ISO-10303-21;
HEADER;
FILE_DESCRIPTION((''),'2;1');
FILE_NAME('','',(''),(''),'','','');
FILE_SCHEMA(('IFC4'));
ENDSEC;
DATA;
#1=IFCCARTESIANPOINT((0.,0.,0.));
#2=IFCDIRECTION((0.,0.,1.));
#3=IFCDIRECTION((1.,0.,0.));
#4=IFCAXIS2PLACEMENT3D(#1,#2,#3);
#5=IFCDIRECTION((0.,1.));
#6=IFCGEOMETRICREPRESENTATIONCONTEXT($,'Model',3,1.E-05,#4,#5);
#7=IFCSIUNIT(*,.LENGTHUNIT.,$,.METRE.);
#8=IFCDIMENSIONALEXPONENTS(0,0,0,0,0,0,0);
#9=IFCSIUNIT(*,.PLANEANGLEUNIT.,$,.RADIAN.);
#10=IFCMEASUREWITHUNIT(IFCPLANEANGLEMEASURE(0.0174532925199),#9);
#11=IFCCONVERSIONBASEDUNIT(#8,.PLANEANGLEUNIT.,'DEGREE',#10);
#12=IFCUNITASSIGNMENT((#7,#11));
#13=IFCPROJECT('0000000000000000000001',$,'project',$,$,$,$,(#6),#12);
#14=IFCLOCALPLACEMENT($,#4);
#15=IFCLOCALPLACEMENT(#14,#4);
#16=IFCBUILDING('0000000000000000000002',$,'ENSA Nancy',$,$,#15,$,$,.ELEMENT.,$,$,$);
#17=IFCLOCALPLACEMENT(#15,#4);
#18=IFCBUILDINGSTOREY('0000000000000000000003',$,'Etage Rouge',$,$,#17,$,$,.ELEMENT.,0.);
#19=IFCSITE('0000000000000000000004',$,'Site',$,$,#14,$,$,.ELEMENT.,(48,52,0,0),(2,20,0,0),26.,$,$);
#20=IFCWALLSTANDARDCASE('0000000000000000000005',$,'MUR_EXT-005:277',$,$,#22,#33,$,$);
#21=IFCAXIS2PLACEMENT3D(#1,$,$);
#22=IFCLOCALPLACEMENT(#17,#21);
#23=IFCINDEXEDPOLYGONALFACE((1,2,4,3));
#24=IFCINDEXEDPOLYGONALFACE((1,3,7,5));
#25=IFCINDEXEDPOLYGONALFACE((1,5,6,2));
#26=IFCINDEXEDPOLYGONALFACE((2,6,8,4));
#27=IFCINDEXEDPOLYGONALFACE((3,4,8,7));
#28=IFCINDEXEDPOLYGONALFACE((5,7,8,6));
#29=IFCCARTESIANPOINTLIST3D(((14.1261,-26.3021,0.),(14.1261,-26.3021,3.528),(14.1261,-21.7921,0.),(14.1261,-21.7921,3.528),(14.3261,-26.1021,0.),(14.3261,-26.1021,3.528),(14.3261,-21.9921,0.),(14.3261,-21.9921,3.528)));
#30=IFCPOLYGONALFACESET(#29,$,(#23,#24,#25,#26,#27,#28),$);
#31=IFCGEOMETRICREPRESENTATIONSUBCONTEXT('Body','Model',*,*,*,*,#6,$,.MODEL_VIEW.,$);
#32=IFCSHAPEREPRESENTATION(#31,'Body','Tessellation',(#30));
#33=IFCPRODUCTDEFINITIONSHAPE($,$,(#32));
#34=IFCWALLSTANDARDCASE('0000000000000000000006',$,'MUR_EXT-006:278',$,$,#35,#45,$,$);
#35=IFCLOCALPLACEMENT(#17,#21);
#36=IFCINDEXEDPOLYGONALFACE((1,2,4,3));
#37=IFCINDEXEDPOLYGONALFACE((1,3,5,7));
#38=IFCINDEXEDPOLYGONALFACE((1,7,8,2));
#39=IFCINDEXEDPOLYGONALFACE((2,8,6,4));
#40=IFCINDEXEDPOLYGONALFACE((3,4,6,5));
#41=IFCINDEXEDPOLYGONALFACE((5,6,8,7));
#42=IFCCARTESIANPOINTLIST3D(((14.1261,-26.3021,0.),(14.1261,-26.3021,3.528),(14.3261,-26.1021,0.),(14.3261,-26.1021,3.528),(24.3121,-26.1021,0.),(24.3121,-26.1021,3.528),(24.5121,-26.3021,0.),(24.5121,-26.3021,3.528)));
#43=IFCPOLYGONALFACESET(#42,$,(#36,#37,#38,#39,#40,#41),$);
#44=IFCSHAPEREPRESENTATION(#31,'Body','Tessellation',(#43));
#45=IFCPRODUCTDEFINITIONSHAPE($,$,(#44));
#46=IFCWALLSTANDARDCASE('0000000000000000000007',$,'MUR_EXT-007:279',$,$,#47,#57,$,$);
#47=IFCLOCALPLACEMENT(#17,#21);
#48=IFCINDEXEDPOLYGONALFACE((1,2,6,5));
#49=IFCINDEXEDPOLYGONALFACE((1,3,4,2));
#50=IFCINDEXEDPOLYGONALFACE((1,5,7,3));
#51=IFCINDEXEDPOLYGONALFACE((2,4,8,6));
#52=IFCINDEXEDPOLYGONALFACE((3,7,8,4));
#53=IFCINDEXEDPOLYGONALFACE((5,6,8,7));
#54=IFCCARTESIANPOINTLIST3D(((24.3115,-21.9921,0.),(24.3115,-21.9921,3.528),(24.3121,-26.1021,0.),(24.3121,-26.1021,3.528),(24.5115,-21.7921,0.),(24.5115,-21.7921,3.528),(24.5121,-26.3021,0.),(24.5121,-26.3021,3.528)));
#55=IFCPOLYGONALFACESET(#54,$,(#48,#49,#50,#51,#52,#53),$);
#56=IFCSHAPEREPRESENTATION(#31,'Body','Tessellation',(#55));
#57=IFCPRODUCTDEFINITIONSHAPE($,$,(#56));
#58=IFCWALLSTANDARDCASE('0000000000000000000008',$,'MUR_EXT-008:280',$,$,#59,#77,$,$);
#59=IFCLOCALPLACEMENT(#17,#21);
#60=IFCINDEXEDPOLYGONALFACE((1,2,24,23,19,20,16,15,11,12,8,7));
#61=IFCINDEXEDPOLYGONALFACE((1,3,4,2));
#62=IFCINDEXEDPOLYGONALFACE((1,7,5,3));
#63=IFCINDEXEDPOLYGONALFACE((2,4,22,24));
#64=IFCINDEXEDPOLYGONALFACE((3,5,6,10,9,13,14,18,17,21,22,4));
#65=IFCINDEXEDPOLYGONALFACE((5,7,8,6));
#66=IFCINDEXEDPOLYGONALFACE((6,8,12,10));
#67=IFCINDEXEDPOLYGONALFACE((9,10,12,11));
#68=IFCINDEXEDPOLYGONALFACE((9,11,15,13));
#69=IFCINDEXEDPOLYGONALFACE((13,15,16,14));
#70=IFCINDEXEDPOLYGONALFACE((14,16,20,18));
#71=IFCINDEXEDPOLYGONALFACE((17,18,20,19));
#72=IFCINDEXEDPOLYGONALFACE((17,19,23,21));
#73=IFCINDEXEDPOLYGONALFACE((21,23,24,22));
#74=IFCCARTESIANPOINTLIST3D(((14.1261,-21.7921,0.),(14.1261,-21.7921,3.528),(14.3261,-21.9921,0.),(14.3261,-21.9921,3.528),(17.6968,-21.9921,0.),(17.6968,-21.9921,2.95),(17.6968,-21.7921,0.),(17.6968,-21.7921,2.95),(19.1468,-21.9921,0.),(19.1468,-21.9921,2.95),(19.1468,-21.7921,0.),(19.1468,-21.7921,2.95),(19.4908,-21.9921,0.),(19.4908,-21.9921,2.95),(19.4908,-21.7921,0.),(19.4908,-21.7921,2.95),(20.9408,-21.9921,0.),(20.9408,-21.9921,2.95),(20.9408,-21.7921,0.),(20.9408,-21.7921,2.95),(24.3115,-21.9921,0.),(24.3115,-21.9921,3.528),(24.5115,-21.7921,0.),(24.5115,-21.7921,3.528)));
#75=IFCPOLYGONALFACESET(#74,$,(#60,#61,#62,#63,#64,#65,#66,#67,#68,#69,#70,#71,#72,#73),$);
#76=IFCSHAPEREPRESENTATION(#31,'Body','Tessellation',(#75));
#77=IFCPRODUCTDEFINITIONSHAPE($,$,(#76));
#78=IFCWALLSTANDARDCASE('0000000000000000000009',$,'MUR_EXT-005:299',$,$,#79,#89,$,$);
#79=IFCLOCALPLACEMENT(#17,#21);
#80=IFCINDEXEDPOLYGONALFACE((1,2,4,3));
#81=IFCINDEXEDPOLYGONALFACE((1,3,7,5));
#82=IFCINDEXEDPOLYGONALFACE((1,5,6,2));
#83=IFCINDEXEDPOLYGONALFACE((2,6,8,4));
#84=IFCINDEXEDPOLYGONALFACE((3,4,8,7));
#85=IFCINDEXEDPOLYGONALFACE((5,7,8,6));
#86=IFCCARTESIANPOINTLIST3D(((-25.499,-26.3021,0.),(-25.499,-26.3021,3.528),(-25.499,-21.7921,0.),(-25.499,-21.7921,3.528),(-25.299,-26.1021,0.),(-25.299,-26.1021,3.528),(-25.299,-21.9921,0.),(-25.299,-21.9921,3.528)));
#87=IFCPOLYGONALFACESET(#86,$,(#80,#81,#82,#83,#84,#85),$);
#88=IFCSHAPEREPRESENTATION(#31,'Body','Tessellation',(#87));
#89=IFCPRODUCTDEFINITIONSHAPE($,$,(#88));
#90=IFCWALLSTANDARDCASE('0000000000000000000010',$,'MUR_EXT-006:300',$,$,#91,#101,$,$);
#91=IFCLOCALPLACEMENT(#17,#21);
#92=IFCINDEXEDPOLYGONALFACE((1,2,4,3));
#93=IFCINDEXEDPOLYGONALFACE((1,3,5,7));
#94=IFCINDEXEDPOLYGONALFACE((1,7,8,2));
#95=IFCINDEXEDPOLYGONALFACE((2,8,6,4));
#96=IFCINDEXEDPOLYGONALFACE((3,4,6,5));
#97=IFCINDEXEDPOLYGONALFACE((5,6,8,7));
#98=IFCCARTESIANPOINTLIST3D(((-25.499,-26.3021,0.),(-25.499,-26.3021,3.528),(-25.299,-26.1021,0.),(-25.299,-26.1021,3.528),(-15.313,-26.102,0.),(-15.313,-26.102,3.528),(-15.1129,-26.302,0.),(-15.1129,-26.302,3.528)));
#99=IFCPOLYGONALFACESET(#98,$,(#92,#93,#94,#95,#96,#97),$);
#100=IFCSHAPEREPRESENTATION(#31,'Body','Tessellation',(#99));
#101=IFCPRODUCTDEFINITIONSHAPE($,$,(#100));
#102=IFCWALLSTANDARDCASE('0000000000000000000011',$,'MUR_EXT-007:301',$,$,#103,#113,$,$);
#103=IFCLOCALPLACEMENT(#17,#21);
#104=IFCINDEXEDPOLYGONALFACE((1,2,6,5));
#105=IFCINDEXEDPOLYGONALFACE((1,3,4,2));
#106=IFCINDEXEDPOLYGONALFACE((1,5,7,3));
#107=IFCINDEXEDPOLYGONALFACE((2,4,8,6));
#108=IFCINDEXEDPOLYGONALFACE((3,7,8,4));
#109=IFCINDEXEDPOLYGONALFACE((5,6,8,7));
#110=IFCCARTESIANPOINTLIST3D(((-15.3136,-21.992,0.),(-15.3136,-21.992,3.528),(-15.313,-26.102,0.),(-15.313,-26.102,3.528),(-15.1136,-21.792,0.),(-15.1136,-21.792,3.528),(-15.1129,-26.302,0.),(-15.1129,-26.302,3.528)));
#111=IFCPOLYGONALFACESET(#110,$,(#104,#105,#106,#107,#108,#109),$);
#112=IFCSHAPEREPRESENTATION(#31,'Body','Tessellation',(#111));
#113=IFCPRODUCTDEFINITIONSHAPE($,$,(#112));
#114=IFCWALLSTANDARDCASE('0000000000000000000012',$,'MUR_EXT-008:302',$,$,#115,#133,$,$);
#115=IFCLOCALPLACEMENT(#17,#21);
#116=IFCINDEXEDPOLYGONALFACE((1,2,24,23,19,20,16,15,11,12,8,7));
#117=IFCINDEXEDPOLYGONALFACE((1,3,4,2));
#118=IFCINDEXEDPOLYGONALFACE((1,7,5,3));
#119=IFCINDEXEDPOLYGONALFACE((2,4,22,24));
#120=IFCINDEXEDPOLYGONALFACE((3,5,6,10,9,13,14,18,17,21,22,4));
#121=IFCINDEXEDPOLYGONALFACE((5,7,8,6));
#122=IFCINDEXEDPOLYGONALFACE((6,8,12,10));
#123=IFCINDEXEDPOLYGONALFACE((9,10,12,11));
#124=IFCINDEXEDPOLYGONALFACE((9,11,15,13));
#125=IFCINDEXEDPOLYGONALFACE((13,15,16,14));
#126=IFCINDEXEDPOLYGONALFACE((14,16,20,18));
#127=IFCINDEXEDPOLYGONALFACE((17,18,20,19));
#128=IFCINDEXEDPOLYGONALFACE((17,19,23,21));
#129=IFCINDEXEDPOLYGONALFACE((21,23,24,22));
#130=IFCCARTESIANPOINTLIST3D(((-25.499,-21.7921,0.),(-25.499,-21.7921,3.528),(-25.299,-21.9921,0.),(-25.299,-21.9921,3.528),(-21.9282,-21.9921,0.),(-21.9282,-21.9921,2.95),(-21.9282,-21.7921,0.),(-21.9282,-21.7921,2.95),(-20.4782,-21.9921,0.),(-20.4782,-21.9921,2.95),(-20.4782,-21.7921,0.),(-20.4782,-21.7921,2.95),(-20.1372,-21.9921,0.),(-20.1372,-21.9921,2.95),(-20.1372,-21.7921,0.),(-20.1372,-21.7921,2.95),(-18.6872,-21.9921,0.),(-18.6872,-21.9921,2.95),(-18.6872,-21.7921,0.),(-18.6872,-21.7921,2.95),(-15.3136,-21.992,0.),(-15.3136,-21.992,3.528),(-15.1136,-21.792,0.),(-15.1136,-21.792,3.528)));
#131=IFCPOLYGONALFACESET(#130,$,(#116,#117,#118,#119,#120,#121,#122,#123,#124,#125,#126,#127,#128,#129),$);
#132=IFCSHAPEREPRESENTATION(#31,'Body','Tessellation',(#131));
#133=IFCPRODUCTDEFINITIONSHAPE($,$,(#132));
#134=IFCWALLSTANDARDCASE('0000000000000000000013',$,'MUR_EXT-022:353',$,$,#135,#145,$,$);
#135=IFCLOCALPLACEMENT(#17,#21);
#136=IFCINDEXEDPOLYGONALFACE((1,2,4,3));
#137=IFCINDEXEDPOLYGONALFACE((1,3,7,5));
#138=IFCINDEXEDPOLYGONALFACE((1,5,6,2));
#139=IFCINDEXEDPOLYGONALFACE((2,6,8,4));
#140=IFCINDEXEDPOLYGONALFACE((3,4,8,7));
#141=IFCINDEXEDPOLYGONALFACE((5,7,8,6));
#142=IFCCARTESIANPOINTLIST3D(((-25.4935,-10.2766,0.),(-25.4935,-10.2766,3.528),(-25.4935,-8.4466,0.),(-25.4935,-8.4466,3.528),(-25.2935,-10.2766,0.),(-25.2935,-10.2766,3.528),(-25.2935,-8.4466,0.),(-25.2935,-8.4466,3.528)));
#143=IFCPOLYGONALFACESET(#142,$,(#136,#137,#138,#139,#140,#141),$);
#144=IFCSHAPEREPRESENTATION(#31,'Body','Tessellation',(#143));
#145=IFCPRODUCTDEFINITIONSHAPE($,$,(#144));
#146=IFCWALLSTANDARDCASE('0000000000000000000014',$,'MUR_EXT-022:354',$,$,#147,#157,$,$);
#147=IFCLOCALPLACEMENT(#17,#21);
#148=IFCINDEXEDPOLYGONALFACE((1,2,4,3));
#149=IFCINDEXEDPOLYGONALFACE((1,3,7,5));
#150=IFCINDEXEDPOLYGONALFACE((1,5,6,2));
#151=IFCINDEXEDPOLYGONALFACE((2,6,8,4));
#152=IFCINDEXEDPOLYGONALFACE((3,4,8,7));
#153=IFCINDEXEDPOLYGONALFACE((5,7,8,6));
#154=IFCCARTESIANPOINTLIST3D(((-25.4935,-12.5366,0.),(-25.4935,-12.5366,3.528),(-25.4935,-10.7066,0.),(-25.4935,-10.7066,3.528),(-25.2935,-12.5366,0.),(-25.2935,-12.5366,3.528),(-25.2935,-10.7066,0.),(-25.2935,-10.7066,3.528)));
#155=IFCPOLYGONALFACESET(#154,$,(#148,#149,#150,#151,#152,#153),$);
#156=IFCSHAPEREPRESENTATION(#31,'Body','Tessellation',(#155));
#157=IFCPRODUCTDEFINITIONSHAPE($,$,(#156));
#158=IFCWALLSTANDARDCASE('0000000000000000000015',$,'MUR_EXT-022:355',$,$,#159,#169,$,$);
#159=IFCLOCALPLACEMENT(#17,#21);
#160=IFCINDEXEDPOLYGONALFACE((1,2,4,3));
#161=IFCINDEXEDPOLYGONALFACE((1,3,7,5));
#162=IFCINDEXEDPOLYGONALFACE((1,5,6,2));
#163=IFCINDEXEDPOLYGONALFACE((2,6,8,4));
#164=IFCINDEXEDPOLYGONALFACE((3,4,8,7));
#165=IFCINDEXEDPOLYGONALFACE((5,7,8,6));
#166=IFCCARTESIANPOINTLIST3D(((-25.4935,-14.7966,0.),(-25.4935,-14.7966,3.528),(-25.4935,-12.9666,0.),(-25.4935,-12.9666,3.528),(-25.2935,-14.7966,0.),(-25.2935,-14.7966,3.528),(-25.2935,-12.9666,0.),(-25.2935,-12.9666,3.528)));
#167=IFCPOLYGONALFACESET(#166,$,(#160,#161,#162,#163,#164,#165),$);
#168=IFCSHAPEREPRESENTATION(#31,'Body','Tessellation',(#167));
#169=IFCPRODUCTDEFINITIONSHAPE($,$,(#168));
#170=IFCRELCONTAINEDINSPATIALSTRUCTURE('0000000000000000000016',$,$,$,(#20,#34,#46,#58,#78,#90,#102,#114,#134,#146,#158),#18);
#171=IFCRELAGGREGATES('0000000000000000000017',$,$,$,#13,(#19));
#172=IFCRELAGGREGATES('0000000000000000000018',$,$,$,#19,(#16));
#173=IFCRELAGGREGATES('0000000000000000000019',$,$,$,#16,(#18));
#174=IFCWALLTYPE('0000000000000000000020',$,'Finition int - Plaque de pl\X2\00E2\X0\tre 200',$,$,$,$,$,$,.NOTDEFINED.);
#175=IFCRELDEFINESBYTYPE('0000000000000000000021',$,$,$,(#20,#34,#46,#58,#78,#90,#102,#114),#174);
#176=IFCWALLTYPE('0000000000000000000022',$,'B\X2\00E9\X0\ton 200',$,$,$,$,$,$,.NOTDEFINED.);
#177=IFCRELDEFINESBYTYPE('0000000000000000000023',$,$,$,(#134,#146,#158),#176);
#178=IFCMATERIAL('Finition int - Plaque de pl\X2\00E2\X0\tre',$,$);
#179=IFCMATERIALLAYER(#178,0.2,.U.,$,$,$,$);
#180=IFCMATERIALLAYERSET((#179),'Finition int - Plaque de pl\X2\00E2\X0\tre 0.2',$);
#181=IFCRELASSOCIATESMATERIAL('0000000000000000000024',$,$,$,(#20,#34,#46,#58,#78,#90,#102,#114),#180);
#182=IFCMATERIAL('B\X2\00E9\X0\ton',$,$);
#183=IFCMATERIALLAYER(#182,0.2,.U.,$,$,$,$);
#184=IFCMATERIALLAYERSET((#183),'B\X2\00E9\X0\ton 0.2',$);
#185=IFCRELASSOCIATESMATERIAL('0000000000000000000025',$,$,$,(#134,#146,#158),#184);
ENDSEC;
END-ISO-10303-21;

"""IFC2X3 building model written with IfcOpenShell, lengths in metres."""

from ifc_helpers import new_model, entity, si_unit, converted_unit, direction, frame, origin_with_axes, origin_2d_with_axis, place, context, subcontext, project, spatial, polyline, rectangle, outline, extrude, material, layer, layer_set, layer_usage, type_object, element, save


model = new_model("IFC2X3")

# Units and contexts
model_context = context("Model", 3, precision=1e-05, world=origin_with_axes(), true_north=direction((0.0, 1.0)))
body_context = subcontext(model_context, "Body", "Model", "MODEL_VIEW")
ifc_project = project(units=[si_unit("LENGTHUNIT", "METRE"), converted_unit("PLANEANGLEUNIT", "DEGREE", entity("IfcPlaneAngleMeasure", 0.0174532925199), si_unit("PLANEANGLEUNIT", "RADIAN"), dimensions=[0, 0, 0, 0, 0, 0, 0])], contexts=[model_context])

# Site, building, storey
site_placement = place(None, origin_with_axes())
site = spatial("IfcSite", under=ifc_project, at=site_placement, Name="Site", CompositionType="ELEMENT", RefLatitude=(48, 52, 0, 0), RefLongitude=(2, 20, 0, 0), RefElevation=26.0)
building_placement = place(site_placement, origin_with_axes())
building = spatial("IfcBuilding", under=site, at=building_placement, Name="ENSA Nancy", CompositionType="ELEMENT")
storey_placement = place(building_placement, origin_with_axes())
storey = spatial("IfcBuildingStorey", under=building, at=storey_placement, Name="Etage Rouge", CompositionType="ELEMENT", Elevation=0.0)

# Walls
ifc_material_1 = material(Name="Finition int - Plaque de plâtre")
ifc_layer_1 = layer(ifc_material_1, 0.2, ventilated="UNKNOWN")
ifc_layer_set_1 = layer_set([ifc_layer_1], Name="Finition int - Plaque de plâtre 0.2")
ifc_layer_usage_1 = layer_usage(ifc_layer_set_1, "AXIS2", "POSITIVE", 0.0)
wall_type_1 = type_object("IfcWallType", Name="Finition int - Plaque de plâtre 200", PredefinedType="NOTDEFINED")
wall_1_placement = place(storey_placement, frame((14.1261, -21.7921, 0.0), z_axis=(0.0, 0.0, 1.0), x_axis=(0.0, -1.0, 0.0)))
element("IfcWallStandardCase", 1, at=wall_1_placement, inside=storey, type_object=wall_type_1, material=ifc_layer_usage_1, Name="MUR_EXT-005:277", context=body_context, shape_type="SweptSolid", body=[
    extrude(outline(polyline([(0.0, 0.0), (4.51, 0.0), (4.31, 0.2), (0.2, 0.2), (0.0, 0.0)])), origin_with_axes(), (0.0, 0.0, 1.0), 3.528),
])
ifc_layer_usage_2 = layer_usage(ifc_layer_set_1, "AXIS2", "POSITIVE", 0.0)
wall_2_placement = place(storey_placement, frame((14.1261, -26.3021, 0.0), z_axis=(0.0, 0.0, 1.0), x_axis=(1.0, 0.000003, 0.0)))
element("IfcWallStandardCase", 2, at=wall_2_placement, inside=storey, type_object=wall_type_1, material=ifc_layer_usage_2, Name="MUR_EXT-006:278", context=body_context, shape_type="SweptSolid", body=[
    extrude(outline(polyline([(0.0, 0.0), (10.386, 0.0), (10.186, 0.2), (0.2, 0.2), (0.0, 0.0)])), origin_with_axes(), (0.0, 0.0, 1.0), 3.528),
])
ifc_layer_usage_3 = layer_usage(ifc_layer_set_1, "AXIS2", "POSITIVE", 0.0)
wall_3_placement = place(storey_placement, frame((24.5121, -26.3021, 0.0), z_axis=(0.0, 0.0, 1.0), x_axis=(-0.00015, 1.0, 0.0)))
element("IfcWallStandardCase", 3, at=wall_3_placement, inside=storey, type_object=wall_type_1, material=ifc_layer_usage_3, Name="MUR_EXT-007:279", context=body_context, shape_type="SweptSolid", body=[
    extrude(outline(polyline([(0.0, 0.0), (4.51, 0.0), (4.31, 0.2), (0.2, 0.2), (0.0, 0.0)])), origin_with_axes(), (0.0, 0.0, 1.0), 3.528),
])

# Wall, openings
ifc_layer_usage_4 = layer_usage(ifc_layer_set_1, "AXIS2", "POSITIVE", 0.0)
wall_4_placement = place(storey_placement, frame((24.5115, -21.7921, 0.0), z_axis=(0.0, 0.0, 1.0), x_axis=(-1.0, -0.000003, 0.0)))
wall_4 = element("IfcWallStandardCase", 4, at=wall_4_placement, inside=storey, type_object=wall_type_1, material=ifc_layer_usage_4, Name="MUR_EXT-008:280", context=body_context, shape_type="SweptSolid", body=[
    extrude(outline(polyline([(0.0, 0.0), (10.3854, 0.0), (10.1854, 0.2), (0.2, 0.2), (0.0, 0.0)])), origin_with_axes(), (0.0, 0.0, 1.0), 3.528),
])
opening_1_placement = place(wall_4_placement, frame((6.0896, 0.0, 0.0), z_axis=(0.0, 0.0, 1.0), x_axis=(1.0, 0.0, 0.0)))
element("IfcOpeningElement", 5, at=opening_1_placement, cuts=wall_4, context=body_context, shape_type="SweptSolid", body=[
    extrude(rectangle(XDim=1.45, YDim=2.95, at=origin_2d_with_axis()), frame((0.0, 0.2, 1.475), z_axis=(0.0, 1.0, 0.0), x_axis=(1.0, 0.0, 0.0)), (0.0, 0.0, -1.0), 0.6),
])
opening_2_placement = place(wall_4_placement, frame((4.2956, 0.0, 0.0), z_axis=(0.0, 0.0, 1.0), x_axis=(1.0, 0.0, 0.0)))
element("IfcOpeningElement", 6, at=opening_2_placement, cuts=wall_4, context=body_context, shape_type="SweptSolid", body=[
    extrude(rectangle(XDim=1.45, YDim=2.95, at=origin_2d_with_axis()), frame((0.0, 0.2, 1.475), z_axis=(0.0, -1.0, 0.0), x_axis=(-1.0, 0.0, 0.0)), (0.0, 0.0, 1.0), 0.6),
])

# Walls
ifc_layer_usage_5 = layer_usage(ifc_layer_set_1, "AXIS2", "POSITIVE", 0.0)
wall_5_placement = place(storey_placement, frame((-25.499, -21.7921, 0.0), z_axis=(0.0, 0.0, 1.0), x_axis=(0.0, -1.0, 0.0)))
element("IfcWallStandardCase", 7, at=wall_5_placement, inside=storey, type_object=wall_type_1, material=ifc_layer_usage_5, Name="MUR_EXT-005:299", context=body_context, shape_type="SweptSolid", body=[
    extrude(outline(polyline([(0.0, 0.0), (4.51, 0.0), (4.31, 0.2), (0.2, 0.2), (0.0, 0.0)])), origin_with_axes(), (0.0, 0.0, 1.0), 3.528),
])
ifc_layer_usage_6 = layer_usage(ifc_layer_set_1, "AXIS2", "POSITIVE", 0.0)
wall_6_placement = place(storey_placement, frame((-25.499, -26.3021, 0.0), z_axis=(0.0, 0.0, 1.0), x_axis=(1.0, 0.000003, 0.0)))
element("IfcWallStandardCase", 8, at=wall_6_placement, inside=storey, type_object=wall_type_1, material=ifc_layer_usage_6, Name="MUR_EXT-006:300", context=body_context, shape_type="SweptSolid", body=[
    extrude(outline(polyline([(0.0, 0.0), (10.386, 0.0), (10.186, 0.2), (0.2, 0.2), (0.0, 0.0)])), origin_with_axes(), (0.0, 0.0, 1.0), 3.528),
])
ifc_layer_usage_7 = layer_usage(ifc_layer_set_1, "AXIS2", "POSITIVE", 0.0)
wall_7_placement = place(storey_placement, frame((-15.1129, -26.302, 0.0), z_axis=(0.0, 0.0, 1.0), x_axis=(-0.00015, 1.0, 0.0)))
element("IfcWallStandardCase", 9, at=wall_7_placement, inside=storey, type_object=wall_type_1, material=ifc_layer_usage_7, Name="MUR_EXT-007:301", context=body_context, shape_type="SweptSolid", body=[
    extrude(outline(polyline([(0.0, 0.0), (4.51, 0.0), (4.31, 0.2), (0.2, 0.2), (0.0, 0.0)])), origin_with_axes(), (0.0, 0.0, 1.0), 3.528),
])

# Wall, openings
ifc_layer_usage_8 = layer_usage(ifc_layer_set_1, "AXIS2", "POSITIVE", 0.0)
wall_8_placement = place(storey_placement, frame((-15.1136, -21.792, 0.0), z_axis=(0.0, 0.0, 1.0), x_axis=(-1.0, -0.000003, 0.0)))
wall_8 = element("IfcWallStandardCase", 10, at=wall_8_placement, inside=storey, type_object=wall_type_1, material=ifc_layer_usage_8, Name="MUR_EXT-008:302", context=body_context, shape_type="SweptSolid", body=[
    extrude(outline(polyline([(0.0, 0.0), (10.3854, 0.0), (10.1854, 0.2), (0.2, 0.2), (0.0, 0.0)])), origin_with_axes(), (0.0, 0.0, 1.0), 3.528),
])
opening_3_placement = place(wall_8_placement, frame((6.0896, 0.0, 0.0), z_axis=(0.0, 0.0, 1.0), x_axis=(1.0, 0.0, 0.0)))
element("IfcOpeningElement", 11, at=opening_3_placement, cuts=wall_8, context=body_context, shape_type="SweptSolid", body=[
    extrude(rectangle(XDim=1.45, YDim=2.95, at=origin_2d_with_axis()), frame((0.0, 0.2, 1.475), z_axis=(0.0, 1.0, 0.0), x_axis=(1.0, 0.0, 0.0)), (0.0, 0.0, -1.0), 0.6),
])
opening_4_placement = place(wall_8_placement, frame((4.2986, 0.0, 0.0), z_axis=(0.0, 0.0, 1.0), x_axis=(1.0, 0.0, 0.0)))
element("IfcOpeningElement", 12, at=opening_4_placement, cuts=wall_8, context=body_context, shape_type="SweptSolid", body=[
    extrude(rectangle(XDim=1.45, YDim=2.95, at=origin_2d_with_axis()), frame((0.0, 0.2, 1.475), z_axis=(0.0, -1.0, 0.0), x_axis=(-1.0, 0.0, 0.0)), (0.0, 0.0, 1.0), 0.6),
])

# Walls
ifc_material_2 = material(Name="Béton")
ifc_layer_2 = layer(ifc_material_2, 0.2, ventilated="UNKNOWN")
ifc_layer_set_2 = layer_set([ifc_layer_2], Name="Béton 0.2")
ifc_layer_usage_9 = layer_usage(ifc_layer_set_2, "AXIS2", "POSITIVE", -0.2)
wall_type_2 = type_object("IfcWallType", Name="Béton 200", PredefinedType="NOTDEFINED")
wall_9_placement = place(storey_placement, frame((-25.2935, -8.4466, 0.0), z_axis=(0.0, 0.0, 1.0), x_axis=(0.0, -1.0, 0.0)))
element("IfcWallStandardCase", 13, at=wall_9_placement, inside=storey, type_object=wall_type_2, material=ifc_layer_usage_9, Name="MUR_EXT-022:353", context=body_context, shape_type="SweptSolid", body=[
    extrude(outline(polyline([(0.0, -0.2), (1.83, -0.2), (1.83, 0.0), (0.0, 0.0), (0.0, -0.2)])), origin_with_axes(), (0.0, 0.0, 1.0), 3.528),
])
ifc_layer_usage_10 = layer_usage(ifc_layer_set_2, "AXIS2", "POSITIVE", -0.2)
wall_10_placement = place(storey_placement, frame((-25.2935, -10.7066, 0.0), z_axis=(0.0, 0.0, 1.0), x_axis=(0.0, -1.0, 0.0)))
element("IfcWallStandardCase", 14, at=wall_10_placement, inside=storey, type_object=wall_type_2, material=ifc_layer_usage_10, Name="MUR_EXT-022:354", context=body_context, shape_type="SweptSolid", body=[
    extrude(outline(polyline([(0.0, -0.2), (1.83, -0.2), (1.83, 0.0), (0.0, 0.0), (0.0, -0.2)])), origin_with_axes(), (0.0, 0.0, 1.0), 3.528),
])
ifc_layer_usage_11 = layer_usage(ifc_layer_set_2, "AXIS2", "POSITIVE", -0.2)
wall_11_placement = place(storey_placement, frame((-25.2935, -12.9666, 0.0), z_axis=(0.0, 0.0, 1.0), x_axis=(0.0, -1.0, 0.0)))
element("IfcWallStandardCase", 15, at=wall_11_placement, inside=storey, type_object=wall_type_2, material=ifc_layer_usage_11, Name="MUR_EXT-022:355", context=body_context, shape_type="SweptSolid", body=[
    extrude(outline(polyline([(0.0, -0.2), (1.83, -0.2), (1.83, 0.0), (0.0, 0.0), (0.0, -0.2)])), origin_with_axes(), (0.0, 0.0, 1.0), 3.528),
])

save(model, "model.ifc")
